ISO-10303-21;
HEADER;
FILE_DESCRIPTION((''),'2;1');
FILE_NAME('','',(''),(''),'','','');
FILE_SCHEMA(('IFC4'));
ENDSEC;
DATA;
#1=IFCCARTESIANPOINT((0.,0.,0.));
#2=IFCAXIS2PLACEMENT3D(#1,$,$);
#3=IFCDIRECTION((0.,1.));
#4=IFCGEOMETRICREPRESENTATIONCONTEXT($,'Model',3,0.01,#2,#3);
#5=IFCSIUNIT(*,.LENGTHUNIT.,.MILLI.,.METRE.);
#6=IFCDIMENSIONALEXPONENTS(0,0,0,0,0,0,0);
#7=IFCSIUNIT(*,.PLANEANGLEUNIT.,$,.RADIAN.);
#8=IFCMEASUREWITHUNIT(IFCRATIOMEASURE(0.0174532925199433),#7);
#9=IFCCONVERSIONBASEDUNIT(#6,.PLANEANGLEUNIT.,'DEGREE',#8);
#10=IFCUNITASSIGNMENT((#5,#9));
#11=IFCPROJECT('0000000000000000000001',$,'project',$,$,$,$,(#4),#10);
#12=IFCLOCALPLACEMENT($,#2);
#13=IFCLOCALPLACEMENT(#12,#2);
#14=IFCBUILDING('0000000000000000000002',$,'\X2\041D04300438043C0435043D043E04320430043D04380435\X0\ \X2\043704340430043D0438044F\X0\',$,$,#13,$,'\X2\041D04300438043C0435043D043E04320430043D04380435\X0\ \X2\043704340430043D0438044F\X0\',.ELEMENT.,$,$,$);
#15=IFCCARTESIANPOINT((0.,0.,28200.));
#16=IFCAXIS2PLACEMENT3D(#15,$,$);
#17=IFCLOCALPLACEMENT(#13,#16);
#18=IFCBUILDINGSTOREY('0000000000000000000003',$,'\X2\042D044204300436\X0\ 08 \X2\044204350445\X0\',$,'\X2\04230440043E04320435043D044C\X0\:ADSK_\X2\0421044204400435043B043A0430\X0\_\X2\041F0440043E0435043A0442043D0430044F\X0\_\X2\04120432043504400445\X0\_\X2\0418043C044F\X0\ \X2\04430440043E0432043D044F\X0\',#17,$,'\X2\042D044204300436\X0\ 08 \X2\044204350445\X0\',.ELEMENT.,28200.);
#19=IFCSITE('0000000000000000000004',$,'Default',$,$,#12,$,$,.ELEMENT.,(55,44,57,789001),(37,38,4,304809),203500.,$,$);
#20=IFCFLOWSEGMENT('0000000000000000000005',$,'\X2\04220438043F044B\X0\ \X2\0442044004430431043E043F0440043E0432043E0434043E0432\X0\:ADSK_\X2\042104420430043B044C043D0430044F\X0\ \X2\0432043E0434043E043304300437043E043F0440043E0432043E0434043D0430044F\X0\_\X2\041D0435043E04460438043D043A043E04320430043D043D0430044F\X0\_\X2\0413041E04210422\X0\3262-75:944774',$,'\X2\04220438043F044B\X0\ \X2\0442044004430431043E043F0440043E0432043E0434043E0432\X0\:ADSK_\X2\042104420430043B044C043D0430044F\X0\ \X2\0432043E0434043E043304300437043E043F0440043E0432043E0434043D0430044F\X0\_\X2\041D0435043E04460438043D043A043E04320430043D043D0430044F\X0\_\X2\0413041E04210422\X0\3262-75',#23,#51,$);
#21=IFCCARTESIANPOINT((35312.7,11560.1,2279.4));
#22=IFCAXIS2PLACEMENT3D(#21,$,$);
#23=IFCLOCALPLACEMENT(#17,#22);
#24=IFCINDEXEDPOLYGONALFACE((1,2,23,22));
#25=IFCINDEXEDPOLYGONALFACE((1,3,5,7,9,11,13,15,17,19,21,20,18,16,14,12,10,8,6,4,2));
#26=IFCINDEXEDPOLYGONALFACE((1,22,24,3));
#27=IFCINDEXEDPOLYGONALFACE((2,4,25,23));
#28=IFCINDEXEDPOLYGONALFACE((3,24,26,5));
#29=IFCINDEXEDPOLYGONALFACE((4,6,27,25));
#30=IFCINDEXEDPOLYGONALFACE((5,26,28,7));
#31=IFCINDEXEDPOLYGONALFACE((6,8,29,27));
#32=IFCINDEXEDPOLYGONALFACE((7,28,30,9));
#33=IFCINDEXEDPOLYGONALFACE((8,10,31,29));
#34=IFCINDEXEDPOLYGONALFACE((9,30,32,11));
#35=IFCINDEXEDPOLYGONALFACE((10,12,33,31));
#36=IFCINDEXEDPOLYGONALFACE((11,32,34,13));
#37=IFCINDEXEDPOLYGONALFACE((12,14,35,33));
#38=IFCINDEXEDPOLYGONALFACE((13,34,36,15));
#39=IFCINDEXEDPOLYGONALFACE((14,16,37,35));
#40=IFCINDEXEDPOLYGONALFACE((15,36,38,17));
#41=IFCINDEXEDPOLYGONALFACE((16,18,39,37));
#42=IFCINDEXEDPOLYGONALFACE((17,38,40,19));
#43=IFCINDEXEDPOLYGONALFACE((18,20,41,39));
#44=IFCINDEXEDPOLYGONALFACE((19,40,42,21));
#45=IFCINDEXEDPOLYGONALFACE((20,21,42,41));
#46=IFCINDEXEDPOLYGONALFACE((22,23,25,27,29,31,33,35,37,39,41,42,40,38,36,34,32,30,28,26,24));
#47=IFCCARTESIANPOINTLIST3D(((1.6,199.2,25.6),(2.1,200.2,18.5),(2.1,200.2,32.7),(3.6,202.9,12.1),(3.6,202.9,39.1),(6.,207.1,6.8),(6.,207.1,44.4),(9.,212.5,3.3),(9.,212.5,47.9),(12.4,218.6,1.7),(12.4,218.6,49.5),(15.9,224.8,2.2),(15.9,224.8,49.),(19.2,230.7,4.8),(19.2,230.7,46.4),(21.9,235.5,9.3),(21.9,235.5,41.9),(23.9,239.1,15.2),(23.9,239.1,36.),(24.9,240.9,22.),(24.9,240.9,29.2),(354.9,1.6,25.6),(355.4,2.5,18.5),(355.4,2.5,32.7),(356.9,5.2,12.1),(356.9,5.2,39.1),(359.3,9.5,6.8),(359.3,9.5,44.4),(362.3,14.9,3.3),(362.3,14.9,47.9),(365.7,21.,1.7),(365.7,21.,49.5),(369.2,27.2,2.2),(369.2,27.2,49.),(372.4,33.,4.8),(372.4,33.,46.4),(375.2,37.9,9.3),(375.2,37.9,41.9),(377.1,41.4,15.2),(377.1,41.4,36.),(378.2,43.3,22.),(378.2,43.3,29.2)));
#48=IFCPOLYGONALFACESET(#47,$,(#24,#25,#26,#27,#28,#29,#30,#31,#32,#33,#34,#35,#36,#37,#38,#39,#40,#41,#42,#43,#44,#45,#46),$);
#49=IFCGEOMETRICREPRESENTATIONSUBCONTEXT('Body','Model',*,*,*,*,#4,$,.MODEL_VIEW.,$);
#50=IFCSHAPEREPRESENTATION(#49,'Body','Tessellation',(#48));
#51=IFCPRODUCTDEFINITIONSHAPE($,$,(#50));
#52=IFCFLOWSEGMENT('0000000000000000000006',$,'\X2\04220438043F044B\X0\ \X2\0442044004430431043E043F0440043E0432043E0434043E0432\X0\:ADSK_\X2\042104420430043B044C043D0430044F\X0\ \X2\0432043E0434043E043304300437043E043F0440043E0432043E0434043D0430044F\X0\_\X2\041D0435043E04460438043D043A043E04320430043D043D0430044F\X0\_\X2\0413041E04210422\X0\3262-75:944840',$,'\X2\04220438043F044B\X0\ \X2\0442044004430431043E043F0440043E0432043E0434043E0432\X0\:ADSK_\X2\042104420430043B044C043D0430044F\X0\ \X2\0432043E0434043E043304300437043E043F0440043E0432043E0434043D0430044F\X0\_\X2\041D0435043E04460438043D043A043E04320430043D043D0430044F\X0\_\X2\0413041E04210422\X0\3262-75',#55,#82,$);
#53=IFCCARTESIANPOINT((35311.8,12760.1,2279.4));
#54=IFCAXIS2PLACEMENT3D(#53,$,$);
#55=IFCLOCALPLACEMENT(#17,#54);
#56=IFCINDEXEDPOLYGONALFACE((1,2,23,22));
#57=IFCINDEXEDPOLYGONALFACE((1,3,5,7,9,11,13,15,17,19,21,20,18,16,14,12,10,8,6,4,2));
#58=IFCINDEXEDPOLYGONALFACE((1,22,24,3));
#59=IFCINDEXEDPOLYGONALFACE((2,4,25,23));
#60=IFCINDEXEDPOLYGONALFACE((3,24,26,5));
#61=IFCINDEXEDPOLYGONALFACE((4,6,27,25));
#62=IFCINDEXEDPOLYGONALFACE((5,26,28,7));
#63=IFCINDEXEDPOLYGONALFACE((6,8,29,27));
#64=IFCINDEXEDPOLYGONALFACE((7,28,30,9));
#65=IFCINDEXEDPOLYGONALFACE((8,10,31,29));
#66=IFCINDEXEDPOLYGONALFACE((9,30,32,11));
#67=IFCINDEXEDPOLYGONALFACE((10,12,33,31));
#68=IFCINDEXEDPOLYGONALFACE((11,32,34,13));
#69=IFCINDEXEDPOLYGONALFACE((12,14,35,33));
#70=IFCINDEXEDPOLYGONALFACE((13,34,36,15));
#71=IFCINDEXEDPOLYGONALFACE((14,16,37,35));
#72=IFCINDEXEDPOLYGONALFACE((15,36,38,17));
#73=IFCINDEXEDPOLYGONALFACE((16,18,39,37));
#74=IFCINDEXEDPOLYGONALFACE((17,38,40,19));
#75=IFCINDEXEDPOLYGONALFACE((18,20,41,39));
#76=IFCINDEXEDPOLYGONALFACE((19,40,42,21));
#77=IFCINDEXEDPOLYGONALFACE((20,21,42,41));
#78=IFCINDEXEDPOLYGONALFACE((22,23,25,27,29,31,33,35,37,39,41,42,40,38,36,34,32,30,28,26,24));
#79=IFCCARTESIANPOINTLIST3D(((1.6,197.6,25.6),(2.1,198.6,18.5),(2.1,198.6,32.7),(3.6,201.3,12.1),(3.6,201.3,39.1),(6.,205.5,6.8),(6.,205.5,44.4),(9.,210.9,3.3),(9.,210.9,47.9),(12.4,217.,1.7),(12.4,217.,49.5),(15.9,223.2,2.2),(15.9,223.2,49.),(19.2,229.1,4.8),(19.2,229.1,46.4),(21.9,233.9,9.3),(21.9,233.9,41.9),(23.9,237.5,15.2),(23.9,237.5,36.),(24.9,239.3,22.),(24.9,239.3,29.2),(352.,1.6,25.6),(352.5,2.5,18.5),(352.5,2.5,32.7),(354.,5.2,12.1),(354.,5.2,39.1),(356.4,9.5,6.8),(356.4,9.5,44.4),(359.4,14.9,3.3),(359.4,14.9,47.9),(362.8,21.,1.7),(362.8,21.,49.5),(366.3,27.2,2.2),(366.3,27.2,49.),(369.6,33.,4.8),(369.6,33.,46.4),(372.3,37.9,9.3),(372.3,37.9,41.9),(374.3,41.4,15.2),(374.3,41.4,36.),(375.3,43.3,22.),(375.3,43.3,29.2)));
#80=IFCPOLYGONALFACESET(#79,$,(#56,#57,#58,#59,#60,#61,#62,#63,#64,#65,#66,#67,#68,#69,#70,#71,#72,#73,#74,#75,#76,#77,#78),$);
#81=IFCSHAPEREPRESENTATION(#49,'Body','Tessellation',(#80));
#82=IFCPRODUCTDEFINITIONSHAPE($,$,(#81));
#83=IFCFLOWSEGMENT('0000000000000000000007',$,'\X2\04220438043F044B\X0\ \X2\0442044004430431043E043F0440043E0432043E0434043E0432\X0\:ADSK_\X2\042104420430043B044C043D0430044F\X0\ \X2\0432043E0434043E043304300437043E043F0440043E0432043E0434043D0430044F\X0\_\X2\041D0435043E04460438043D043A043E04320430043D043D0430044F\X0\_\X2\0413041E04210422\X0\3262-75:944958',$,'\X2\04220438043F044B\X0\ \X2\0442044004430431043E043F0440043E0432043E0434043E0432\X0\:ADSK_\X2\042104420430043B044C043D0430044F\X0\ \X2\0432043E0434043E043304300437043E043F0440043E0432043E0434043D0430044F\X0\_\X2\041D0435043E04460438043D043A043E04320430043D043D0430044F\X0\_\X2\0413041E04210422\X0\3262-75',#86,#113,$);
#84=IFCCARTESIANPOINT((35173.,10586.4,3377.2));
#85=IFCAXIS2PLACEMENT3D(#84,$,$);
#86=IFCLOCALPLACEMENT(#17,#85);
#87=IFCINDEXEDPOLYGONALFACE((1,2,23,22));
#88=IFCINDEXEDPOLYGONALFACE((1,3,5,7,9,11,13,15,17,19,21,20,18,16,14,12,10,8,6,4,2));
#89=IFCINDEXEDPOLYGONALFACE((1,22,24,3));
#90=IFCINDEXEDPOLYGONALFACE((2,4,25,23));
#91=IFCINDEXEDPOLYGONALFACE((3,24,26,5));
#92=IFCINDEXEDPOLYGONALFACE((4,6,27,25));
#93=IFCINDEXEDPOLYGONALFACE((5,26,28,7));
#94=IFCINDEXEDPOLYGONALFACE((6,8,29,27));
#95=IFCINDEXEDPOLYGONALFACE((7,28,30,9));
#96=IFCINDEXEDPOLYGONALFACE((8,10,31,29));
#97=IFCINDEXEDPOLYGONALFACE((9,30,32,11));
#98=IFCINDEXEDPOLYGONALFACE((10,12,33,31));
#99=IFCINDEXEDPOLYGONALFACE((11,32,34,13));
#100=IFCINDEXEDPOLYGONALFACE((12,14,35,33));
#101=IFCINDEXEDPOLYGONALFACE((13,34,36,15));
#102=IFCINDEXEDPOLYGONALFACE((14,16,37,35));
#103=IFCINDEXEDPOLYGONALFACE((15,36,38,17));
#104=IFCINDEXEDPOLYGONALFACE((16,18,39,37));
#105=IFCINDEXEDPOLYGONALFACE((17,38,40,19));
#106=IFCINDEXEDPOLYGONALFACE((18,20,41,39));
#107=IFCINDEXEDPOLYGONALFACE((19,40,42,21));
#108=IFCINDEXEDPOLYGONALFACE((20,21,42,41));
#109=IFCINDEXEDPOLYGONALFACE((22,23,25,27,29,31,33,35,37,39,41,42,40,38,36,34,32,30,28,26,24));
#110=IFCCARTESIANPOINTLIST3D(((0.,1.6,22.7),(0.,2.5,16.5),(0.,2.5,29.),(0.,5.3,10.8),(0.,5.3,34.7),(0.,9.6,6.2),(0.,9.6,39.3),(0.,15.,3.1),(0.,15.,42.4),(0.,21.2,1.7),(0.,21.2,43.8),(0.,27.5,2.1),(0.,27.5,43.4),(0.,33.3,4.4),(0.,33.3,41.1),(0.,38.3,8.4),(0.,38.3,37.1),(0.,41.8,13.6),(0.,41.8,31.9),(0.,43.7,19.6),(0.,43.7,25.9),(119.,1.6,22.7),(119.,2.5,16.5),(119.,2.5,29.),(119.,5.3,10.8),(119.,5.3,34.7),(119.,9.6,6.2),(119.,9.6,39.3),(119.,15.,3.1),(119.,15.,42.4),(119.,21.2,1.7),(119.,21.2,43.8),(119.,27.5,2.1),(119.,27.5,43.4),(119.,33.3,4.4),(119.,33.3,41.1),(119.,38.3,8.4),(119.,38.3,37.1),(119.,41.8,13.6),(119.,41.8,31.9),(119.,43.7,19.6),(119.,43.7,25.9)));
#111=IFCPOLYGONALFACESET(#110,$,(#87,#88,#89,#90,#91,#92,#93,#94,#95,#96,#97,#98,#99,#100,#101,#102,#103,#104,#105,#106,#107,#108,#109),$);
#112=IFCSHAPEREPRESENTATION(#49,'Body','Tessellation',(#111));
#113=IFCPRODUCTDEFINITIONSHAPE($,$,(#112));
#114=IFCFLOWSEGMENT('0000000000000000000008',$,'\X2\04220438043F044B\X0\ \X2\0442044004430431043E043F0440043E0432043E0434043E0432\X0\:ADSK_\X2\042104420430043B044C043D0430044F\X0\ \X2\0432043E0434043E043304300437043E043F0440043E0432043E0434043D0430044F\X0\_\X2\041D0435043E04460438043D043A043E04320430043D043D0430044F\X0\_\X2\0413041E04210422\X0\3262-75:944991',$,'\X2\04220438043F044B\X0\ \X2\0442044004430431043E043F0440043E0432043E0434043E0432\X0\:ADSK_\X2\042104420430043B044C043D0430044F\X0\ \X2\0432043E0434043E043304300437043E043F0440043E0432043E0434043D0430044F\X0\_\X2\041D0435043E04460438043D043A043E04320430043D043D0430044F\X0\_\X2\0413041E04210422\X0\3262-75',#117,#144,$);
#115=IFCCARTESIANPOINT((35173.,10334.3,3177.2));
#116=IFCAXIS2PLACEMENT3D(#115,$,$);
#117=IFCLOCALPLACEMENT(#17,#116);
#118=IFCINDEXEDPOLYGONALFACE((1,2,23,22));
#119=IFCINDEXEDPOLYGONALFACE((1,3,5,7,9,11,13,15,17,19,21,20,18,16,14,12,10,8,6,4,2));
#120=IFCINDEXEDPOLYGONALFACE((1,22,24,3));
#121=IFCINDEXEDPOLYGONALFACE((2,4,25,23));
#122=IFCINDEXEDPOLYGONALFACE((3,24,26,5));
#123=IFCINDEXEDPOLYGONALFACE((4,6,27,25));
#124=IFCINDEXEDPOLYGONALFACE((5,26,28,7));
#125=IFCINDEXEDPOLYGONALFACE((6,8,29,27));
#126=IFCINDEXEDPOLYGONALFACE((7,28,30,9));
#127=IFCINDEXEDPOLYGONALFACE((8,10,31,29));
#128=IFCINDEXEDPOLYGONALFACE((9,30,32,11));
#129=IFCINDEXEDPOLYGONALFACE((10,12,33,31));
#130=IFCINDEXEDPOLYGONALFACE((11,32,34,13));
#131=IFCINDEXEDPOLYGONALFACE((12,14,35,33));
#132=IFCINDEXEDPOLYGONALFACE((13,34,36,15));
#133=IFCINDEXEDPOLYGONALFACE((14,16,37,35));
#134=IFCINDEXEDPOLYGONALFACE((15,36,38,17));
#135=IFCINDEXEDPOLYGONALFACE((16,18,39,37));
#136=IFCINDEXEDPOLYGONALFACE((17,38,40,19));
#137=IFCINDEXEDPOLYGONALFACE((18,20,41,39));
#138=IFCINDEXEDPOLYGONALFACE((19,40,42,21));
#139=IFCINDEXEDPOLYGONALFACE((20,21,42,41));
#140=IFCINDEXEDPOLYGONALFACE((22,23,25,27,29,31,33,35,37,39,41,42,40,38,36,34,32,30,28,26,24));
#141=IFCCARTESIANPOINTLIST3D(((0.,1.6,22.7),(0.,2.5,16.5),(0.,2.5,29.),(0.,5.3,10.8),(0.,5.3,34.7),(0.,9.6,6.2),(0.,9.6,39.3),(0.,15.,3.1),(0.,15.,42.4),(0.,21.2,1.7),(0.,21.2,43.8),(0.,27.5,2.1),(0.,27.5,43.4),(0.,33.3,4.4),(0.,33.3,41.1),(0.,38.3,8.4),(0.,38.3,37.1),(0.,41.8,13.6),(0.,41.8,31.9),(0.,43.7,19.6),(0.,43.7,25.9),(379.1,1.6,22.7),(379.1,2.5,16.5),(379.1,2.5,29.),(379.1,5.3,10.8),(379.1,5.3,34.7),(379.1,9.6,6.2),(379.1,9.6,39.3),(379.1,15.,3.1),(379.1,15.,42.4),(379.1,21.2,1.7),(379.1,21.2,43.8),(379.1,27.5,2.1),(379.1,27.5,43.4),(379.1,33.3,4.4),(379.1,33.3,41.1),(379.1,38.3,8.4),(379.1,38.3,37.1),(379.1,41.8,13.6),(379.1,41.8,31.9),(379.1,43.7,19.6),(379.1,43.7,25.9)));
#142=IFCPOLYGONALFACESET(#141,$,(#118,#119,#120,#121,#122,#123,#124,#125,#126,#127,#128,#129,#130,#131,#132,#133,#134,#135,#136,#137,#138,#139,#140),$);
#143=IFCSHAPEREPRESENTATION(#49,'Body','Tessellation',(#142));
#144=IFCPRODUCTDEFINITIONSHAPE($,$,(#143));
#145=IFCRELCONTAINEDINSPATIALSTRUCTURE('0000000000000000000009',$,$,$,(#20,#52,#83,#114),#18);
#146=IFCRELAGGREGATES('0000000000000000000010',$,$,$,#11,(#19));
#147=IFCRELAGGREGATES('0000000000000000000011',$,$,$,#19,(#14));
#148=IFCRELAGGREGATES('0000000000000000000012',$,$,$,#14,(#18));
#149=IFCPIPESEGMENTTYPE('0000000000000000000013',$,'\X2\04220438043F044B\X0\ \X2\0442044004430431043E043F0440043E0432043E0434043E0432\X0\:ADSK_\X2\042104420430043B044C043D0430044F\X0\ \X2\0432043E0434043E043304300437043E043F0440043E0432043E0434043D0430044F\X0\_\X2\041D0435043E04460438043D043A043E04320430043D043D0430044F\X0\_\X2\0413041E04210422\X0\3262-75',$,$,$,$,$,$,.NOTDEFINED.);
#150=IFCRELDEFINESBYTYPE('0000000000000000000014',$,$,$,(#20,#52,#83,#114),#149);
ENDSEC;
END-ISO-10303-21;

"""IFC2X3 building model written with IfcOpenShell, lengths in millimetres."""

from ifc_helpers import new_model, entity, si_unit, converted_unit, direction, frame, origin, origin_2d_with_axis, place, context, subcontext, project, spatial, circle, extrude, type_object, element, save


model = new_model("IFC2X3")

# Units and contexts
model_context = context("Model", 3, precision=0.01, world=origin(), true_north=direction((0.0, 1.0)))
body_context = subcontext(model_context, "Body", "Model", "MODEL_VIEW")
ifc_project = project(units=[si_unit("LENGTHUNIT", "METRE", prefix="MILLI"), converted_unit("PLANEANGLEUNIT", "DEGREE", entity("IfcRatioMeasure", 0.0174532925199433), si_unit("PLANEANGLEUNIT", "RADIAN"), dimensions=[0, 0, 0, 0, 0, 0, 0])], contexts=[model_context])

# Site, building, storey
site_placement = place(None, origin())
site = spatial("IfcSite", under=ifc_project, at=site_placement, Name="Default", CompositionType="ELEMENT", RefLatitude=(55, 44, 57, 789001), RefLongitude=(37, 38, 4, 304809), RefElevation=203500.0)
building_placement = place(site_placement, origin())
building = spatial("IfcBuilding", under=site, at=building_placement, Name="Наименование здания", LongName="Наименование здания", CompositionType="ELEMENT")
storey_placement = place(building_placement, frame((0.0, 0.0, 28200.0)))
storey = spatial("IfcBuildingStorey", under=building, at=storey_placement, Name="Этаж 08 тех", ObjectType="Уровень:ADSK_Стрелка_Проектная_Вверх_Имя уровня", LongName="Этаж 08 тех", CompositionType="ELEMENT", Elevation=28200.0)

# Flow segments
pipe_segment_type = type_object("IfcPipeSegmentType", Name="Типы трубопроводов:ADSK_Стальная водогазопроводная_Неоцинкованная_ГОСТ3262-75", PredefinedType="NOTDEFINED")
flow_segment_1_placement = place(storey_placement, frame((35312.7, 11560.1, 2279.4)))
element("IfcFlowSegment", 1, at=flow_segment_1_placement, inside=storey, type_object=pipe_segment_type, Name="Типы трубопроводов:ADSK_Стальная водогазопроводная_Неоцинкованная_ГОСТ3262-75:944774", ObjectType="Типы трубопроводов:ADSK_Стальная водогазопроводная_Неоцинкованная_ГОСТ3262-75", context=body_context, shape_type="SweptSolid", body=[
    extrude(circle(Radius=24.0, at=origin_2d_with_axis()), frame((13.3, 220.2, 25.6), z_axis=(0.87271, -0.488239, 0.0), x_axis=(-0.488239, -0.87271, 0.0)), (0.0, 0.0, 1.0), 404.8),
])
flow_segment_2_placement = place(storey_placement, frame((35311.8, 12760.1, 2279.4)))
element("IfcFlowSegment", 2, at=flow_segment_2_placement, inside=storey, type_object=pipe_segment_type, Name="Типы трубопроводов:ADSK_Стальная водогазопроводная_Неоцинкованная_ГОСТ3262-75:944840", ObjectType="Типы трубопроводов:ADSK_Стальная водогазопроводная_Неоцинкованная_ГОСТ3262-75", context=body_context, shape_type="SweptSolid", body=[
    extrude(circle(Radius=24.0, at=origin_2d_with_axis()), frame((13.3, 218.6, 25.6), z_axis=(0.87271, -0.488239, 0.0), x_axis=(-0.488239, -0.87271, 0.0)), (0.0, 0.0, 1.0), 401.5),
])
flow_segment_3_placement = place(storey_placement, frame((35173.0, 10586.4, 3377.2)))
element("IfcFlowSegment", 3, at=flow_segment_3_placement, inside=storey, type_object=pipe_segment_type, Name="Типы трубопроводов:ADSK_Стальная водогазопроводная_Неоцинкованная_ГОСТ3262-75:944958", ObjectType="Типы трубопроводов:ADSK_Стальная водогазопроводная_Неоцинкованная_ГОСТ3262-75", context=body_context, shape_type="SweptSolid", body=[
    extrude(circle(Radius=21.1, at=origin_2d_with_axis()), frame((0.0, 22.8, 22.8), z_axis=(1.0, 0.0, 0.0), x_axis=(0.0, -1.0, 0.0)), (0.0, 0.0, 1.0), 119.0),
])
flow_segment_4_placement = place(storey_placement, frame((35173.0, 10334.3, 3177.2)))
element("IfcFlowSegment", 4, at=flow_segment_4_placement, inside=storey, type_object=pipe_segment_type, Name="Типы трубопроводов:ADSK_Стальная водогазопроводная_Неоцинкованная_ГОСТ3262-75:944991", ObjectType="Типы трубопроводов:ADSK_Стальная водогазопроводная_Неоцинкованная_ГОСТ3262-75", context=body_context, shape_type="SweptSolid", body=[
    extrude(circle(Radius=21.1, at=origin_2d_with_axis()), frame((0.0, 22.8, 22.8), z_axis=(1.0, 0.0, 0.0), x_axis=(0.0, -1.0, 0.0)), (0.0, 0.0, 1.0), 379.1),
])

save(model, "model.ifc")
